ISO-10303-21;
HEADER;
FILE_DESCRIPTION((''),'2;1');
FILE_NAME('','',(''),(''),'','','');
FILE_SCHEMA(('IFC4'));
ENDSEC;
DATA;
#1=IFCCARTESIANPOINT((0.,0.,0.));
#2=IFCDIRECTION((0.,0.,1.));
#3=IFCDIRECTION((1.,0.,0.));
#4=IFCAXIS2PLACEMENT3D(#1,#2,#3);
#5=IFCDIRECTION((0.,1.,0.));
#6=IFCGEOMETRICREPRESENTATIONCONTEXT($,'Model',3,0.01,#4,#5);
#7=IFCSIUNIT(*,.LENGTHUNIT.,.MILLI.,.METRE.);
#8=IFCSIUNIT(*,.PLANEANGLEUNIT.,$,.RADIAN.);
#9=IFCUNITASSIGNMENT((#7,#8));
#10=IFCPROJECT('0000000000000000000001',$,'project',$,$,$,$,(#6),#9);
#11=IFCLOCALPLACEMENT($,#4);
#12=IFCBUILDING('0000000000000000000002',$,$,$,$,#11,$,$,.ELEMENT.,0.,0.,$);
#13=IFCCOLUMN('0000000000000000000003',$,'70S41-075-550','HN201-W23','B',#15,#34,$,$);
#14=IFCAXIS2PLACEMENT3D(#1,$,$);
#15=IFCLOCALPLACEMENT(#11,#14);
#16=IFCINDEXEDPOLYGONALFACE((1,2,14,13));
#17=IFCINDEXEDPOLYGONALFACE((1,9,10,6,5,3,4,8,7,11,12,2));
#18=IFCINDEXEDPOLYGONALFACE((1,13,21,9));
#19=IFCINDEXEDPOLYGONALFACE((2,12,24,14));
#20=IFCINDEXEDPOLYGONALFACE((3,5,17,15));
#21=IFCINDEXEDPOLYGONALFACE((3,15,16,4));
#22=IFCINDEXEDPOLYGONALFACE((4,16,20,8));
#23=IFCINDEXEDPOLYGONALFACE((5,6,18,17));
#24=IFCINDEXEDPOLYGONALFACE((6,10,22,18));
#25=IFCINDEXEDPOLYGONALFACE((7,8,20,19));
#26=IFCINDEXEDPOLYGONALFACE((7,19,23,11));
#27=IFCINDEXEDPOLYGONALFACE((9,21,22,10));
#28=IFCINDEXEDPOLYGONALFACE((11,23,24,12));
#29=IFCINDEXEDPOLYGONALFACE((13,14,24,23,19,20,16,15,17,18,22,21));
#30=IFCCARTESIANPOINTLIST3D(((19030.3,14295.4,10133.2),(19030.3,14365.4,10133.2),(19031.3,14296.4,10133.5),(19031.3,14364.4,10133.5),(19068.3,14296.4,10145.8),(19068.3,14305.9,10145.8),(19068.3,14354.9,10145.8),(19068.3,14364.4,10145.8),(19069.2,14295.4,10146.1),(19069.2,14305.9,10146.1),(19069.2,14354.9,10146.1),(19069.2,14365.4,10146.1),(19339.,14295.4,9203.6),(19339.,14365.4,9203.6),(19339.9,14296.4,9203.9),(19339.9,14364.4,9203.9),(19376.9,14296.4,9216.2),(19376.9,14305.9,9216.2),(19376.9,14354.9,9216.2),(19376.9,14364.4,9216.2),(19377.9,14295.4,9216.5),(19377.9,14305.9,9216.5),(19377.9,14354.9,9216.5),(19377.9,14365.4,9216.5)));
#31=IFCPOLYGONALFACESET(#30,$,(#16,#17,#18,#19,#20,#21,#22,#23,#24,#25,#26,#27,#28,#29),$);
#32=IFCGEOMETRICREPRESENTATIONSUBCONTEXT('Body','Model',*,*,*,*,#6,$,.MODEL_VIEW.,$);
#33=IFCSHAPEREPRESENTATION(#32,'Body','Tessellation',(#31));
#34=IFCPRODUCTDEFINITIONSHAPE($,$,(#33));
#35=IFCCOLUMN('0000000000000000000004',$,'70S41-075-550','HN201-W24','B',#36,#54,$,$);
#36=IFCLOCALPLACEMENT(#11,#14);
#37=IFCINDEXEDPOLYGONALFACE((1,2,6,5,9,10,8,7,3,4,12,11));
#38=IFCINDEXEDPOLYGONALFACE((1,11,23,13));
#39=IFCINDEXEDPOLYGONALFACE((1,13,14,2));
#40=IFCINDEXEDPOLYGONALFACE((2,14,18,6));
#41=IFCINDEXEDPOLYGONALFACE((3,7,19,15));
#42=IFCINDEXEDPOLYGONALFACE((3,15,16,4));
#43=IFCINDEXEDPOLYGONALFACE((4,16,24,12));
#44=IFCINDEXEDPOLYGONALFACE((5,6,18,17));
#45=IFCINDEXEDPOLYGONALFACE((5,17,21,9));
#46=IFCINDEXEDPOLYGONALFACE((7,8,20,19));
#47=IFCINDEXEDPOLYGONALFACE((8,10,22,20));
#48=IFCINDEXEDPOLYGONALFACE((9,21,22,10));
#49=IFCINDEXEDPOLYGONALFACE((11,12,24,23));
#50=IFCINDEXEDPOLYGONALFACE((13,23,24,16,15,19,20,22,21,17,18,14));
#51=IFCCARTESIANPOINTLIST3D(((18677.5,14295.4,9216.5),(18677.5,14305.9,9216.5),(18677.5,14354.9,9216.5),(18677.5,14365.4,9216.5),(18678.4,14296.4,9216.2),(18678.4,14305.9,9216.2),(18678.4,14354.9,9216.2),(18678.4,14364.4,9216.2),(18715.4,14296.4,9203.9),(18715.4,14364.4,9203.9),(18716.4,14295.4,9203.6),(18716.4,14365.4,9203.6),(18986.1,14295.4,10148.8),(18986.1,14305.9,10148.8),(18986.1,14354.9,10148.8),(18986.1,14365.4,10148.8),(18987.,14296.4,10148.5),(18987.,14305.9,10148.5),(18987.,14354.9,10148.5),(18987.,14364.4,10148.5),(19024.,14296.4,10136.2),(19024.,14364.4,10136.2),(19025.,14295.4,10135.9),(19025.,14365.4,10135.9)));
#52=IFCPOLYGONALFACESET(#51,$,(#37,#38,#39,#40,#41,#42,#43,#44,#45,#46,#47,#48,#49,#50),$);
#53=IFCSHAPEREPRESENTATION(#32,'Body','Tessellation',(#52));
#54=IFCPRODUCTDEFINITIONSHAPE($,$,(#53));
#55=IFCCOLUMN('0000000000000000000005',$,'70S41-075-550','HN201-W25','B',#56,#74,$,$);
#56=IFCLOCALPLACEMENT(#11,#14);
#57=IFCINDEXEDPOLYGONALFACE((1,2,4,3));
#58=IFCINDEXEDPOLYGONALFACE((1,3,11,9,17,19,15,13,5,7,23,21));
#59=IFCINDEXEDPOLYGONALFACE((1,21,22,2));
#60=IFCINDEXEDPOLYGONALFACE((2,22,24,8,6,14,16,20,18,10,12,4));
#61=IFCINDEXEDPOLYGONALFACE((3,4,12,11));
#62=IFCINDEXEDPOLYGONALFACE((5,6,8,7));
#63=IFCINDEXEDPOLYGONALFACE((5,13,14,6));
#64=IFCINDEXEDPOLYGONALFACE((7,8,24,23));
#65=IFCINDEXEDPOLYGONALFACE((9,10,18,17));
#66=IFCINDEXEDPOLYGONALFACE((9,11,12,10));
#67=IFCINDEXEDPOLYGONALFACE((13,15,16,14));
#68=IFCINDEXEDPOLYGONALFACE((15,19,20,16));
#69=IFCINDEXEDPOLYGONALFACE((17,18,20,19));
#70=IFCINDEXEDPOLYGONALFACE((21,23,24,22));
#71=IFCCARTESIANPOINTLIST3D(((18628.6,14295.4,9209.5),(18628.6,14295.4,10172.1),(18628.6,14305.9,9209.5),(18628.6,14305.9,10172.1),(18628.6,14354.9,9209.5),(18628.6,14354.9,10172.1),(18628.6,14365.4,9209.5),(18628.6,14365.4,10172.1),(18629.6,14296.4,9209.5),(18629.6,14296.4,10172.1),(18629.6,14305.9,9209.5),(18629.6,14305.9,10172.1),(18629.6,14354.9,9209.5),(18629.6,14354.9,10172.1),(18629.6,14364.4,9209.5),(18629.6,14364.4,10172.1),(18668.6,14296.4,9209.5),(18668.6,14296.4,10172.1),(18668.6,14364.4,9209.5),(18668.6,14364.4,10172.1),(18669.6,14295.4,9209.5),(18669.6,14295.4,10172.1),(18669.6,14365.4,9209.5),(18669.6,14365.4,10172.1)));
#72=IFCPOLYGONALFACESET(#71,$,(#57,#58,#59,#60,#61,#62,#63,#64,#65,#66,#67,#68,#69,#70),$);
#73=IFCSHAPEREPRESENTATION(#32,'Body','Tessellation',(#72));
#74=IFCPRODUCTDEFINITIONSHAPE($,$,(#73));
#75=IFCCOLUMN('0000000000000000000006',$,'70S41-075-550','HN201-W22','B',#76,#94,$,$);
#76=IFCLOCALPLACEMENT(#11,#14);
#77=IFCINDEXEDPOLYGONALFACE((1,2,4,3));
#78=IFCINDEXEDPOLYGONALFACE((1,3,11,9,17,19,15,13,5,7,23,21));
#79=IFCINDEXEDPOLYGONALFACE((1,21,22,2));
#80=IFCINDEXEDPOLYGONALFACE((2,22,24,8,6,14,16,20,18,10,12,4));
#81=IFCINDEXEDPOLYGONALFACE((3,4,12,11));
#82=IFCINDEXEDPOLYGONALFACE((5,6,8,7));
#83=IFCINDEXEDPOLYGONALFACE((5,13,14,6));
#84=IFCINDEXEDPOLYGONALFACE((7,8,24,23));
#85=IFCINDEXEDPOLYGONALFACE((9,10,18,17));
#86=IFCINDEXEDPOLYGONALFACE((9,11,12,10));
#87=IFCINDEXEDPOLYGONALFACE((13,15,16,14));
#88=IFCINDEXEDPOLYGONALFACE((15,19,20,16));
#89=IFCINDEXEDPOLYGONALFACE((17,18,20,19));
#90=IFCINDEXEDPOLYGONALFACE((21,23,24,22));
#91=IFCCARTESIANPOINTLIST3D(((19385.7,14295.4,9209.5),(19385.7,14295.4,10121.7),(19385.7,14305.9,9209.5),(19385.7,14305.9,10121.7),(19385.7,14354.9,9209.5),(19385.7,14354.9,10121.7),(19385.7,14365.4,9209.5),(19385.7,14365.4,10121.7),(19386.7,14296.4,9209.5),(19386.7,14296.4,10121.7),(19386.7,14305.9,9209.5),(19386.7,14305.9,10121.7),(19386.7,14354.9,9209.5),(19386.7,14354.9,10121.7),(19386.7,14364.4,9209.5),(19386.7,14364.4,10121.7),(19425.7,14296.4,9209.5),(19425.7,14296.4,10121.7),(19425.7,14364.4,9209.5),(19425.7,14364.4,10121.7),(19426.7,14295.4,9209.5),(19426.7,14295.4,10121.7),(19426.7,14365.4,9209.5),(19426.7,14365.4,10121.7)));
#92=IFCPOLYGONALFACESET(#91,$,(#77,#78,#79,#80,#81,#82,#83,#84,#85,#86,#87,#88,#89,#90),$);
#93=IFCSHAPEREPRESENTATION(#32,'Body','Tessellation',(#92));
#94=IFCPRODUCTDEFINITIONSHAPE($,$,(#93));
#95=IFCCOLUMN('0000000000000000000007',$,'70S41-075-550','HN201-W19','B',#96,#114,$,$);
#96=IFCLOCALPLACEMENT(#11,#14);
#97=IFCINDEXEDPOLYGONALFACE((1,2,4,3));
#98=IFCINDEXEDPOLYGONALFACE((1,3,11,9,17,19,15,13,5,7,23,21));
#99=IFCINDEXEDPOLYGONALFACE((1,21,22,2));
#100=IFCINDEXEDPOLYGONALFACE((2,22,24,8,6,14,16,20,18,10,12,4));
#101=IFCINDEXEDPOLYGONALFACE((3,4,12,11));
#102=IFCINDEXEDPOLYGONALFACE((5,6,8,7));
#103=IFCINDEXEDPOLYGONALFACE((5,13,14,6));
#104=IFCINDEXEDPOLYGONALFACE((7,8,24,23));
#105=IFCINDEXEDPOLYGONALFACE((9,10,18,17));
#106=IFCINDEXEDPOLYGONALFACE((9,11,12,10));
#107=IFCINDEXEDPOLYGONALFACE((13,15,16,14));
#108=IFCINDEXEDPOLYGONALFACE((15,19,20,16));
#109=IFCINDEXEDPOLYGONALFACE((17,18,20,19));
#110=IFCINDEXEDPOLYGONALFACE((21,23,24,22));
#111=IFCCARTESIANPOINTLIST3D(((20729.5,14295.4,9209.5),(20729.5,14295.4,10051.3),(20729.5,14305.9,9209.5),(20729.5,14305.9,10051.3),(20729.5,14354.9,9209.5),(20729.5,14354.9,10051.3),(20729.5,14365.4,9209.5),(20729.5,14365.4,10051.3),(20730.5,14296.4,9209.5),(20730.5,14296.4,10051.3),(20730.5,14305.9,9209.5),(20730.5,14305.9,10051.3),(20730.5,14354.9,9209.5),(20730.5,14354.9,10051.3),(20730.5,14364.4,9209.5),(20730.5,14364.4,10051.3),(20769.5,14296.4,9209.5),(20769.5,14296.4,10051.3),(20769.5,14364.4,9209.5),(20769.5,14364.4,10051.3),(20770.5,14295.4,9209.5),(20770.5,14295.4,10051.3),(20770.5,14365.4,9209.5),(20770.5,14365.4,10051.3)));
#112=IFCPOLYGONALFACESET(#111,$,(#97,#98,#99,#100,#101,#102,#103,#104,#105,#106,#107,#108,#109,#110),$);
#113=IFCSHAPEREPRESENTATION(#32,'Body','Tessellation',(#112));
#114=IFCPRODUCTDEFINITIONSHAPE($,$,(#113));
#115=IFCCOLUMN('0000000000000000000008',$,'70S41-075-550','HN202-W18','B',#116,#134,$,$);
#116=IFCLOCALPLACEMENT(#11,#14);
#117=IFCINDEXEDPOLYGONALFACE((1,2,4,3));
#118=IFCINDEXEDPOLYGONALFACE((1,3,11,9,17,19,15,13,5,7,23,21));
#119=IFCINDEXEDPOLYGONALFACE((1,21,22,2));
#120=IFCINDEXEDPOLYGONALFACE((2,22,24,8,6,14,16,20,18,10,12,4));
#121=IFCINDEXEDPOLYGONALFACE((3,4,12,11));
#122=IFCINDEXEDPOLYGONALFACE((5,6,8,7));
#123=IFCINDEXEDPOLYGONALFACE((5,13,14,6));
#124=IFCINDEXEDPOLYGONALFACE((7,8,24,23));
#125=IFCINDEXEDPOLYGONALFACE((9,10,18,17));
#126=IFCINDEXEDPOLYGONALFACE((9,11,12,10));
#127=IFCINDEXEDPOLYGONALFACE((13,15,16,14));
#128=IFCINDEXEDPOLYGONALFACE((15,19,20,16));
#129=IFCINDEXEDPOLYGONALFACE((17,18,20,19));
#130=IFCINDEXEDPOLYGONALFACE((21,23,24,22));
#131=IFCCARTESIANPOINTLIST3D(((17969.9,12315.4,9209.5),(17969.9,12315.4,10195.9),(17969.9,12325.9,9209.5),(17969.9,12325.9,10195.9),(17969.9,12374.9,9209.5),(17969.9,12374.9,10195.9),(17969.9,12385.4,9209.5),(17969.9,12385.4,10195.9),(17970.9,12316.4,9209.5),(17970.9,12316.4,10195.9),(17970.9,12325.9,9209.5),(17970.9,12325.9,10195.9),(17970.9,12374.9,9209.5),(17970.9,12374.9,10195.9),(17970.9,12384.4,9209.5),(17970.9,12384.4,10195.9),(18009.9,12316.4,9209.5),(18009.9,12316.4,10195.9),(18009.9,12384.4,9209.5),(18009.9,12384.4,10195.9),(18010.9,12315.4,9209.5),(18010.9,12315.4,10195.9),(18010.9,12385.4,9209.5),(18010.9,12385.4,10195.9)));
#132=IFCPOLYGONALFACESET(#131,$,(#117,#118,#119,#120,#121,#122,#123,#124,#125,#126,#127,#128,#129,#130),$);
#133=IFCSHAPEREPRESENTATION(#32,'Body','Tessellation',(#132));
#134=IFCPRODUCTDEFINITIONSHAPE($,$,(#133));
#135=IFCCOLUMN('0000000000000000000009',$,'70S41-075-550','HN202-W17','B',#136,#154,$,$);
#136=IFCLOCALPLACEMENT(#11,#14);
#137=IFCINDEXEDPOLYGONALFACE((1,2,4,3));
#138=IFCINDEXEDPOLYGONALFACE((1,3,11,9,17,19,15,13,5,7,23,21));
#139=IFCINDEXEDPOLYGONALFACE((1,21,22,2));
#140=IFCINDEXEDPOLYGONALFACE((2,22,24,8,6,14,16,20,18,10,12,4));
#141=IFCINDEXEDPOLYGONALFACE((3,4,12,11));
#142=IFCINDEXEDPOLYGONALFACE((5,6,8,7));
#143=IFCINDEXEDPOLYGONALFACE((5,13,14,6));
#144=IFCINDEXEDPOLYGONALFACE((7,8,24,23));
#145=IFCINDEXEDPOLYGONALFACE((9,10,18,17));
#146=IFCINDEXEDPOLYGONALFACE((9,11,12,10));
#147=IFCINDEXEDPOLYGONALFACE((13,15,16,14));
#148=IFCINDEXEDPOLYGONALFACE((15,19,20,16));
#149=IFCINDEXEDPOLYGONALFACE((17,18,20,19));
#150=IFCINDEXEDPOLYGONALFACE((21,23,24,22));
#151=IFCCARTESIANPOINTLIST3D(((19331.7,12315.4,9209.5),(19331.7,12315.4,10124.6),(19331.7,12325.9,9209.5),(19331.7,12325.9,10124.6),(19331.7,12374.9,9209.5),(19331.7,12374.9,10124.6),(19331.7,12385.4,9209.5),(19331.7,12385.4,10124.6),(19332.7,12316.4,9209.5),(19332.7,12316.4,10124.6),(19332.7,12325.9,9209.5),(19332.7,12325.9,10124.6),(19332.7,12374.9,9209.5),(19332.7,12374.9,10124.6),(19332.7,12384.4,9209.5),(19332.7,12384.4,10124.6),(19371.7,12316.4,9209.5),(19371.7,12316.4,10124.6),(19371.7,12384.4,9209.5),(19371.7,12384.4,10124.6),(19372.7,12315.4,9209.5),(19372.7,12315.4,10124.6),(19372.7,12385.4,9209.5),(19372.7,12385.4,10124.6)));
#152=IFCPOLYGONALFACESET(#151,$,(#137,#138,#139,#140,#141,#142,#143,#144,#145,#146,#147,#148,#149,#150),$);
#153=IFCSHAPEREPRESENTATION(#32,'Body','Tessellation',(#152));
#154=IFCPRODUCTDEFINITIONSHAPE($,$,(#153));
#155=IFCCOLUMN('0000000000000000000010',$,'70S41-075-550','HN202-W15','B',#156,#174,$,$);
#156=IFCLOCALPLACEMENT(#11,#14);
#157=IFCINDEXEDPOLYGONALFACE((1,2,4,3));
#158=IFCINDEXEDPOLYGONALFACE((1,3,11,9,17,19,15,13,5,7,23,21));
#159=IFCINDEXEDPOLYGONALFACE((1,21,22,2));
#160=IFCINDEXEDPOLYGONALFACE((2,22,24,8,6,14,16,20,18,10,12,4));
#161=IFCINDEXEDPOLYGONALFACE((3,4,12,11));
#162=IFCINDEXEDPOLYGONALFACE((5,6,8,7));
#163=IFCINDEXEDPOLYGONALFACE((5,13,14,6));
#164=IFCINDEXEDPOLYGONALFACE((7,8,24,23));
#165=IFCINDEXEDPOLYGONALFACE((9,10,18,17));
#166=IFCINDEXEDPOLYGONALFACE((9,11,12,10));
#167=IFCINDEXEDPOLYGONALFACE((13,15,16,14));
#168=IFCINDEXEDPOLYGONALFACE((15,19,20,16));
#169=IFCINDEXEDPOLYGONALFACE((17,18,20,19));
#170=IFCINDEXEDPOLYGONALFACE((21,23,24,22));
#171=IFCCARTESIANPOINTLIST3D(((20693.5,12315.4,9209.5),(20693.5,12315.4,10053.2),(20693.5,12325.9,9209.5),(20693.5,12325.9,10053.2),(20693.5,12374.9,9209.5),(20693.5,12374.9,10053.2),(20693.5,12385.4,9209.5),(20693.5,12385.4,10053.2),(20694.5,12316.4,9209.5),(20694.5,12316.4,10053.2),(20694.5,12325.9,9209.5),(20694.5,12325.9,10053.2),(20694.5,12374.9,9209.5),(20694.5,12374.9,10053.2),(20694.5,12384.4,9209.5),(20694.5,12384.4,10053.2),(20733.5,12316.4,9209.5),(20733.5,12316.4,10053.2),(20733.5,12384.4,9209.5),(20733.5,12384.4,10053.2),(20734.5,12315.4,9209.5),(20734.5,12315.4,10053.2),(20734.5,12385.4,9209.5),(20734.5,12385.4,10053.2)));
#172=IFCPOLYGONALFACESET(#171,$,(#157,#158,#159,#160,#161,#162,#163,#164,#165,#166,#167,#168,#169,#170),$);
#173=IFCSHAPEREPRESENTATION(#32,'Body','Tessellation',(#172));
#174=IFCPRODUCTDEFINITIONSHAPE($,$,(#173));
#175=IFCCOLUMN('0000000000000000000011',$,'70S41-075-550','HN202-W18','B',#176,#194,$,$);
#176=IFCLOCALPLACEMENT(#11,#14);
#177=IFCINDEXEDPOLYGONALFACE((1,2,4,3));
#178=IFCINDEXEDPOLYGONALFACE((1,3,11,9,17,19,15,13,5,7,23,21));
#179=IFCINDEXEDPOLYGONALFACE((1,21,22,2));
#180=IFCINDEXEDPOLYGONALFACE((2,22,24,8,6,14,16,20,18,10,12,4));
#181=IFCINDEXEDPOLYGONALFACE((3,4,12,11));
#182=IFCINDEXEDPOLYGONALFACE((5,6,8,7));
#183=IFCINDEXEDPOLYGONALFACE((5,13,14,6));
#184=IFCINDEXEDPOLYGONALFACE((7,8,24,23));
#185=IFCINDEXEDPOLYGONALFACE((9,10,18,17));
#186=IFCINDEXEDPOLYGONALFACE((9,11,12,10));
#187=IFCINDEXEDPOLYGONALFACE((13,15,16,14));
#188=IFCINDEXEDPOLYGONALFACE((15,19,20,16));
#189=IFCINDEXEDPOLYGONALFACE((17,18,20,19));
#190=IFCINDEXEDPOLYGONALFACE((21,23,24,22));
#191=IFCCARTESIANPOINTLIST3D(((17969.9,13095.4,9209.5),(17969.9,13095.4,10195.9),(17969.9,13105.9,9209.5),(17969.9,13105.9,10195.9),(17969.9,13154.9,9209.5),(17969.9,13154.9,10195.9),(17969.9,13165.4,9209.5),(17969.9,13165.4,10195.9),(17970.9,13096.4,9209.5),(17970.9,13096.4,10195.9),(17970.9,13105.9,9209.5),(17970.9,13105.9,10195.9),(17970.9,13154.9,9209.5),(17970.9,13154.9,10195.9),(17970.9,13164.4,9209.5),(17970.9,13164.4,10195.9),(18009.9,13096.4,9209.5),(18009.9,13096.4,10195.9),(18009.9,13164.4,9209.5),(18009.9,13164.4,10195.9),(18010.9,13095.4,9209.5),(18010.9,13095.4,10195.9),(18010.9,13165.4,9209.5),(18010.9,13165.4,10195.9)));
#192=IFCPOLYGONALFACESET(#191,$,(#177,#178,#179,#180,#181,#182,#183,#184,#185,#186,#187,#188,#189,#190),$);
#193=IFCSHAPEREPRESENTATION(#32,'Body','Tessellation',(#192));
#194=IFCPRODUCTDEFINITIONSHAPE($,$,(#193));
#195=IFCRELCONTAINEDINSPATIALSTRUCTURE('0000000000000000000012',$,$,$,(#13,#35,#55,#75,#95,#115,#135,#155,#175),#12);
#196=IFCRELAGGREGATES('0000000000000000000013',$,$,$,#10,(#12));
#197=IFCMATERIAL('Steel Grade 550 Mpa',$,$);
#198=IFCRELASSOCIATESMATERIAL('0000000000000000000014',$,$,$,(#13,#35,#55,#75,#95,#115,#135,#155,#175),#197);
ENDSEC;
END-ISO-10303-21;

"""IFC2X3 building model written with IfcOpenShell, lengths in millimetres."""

from ifc_helpers import new_model, si_unit, direction, frame, origin, origin_with_axes, origin_2d_with_axis, place, context, subcontext, project, spatial, c_section, extrude, source, transform, mapped, material, element, save


model = new_model("IFC2X3")

# Units and contexts
model_context = context("Model", 3, precision=0.01, world=origin_with_axes(), true_north=direction((0.0, 1.0, 0.0)))
body_context = subcontext(model_context, "Body", "Model", "MODEL_VIEW")
ifc_project = project(units=[si_unit("LENGTHUNIT", "METRE", prefix="MILLI"), si_unit("PLANEANGLEUNIT", "RADIAN")], contexts=[model_context])

# Building
building_placement = place(None, origin_with_axes())
building = spatial("IfcBuilding", under=ifc_project, at=building_placement, CompositionType="ELEMENT", ElevationOfRefHeight=0.0, ElevationOfTerrain=0.0)

# Columns
ifc_material = material(Name="Steel Grade 550 Mpa")
shared_shape_1 = source(origin(), body_context, "Body", "SweptSolid", [
    extrude(c_section(Depth=70.0, Width=41.0, WallThickness=1.0, Girth=10.5, at=origin_2d_with_axis()), origin_with_axes(), (0.0, 0.0, 1.0), 979.5),
])
column_1_placement = place(None, frame((19358.4, 14330.4, 9210.1), z_axis=(-0.315103, 0.0, 0.949058), x_axis=(0.949058, 0.0, 0.315103)))
element("IfcColumn", 1, at=column_1_placement, inside=building, material=ifc_material, Name="70S41-075-550", Description="HN201-W23", ObjectType="B", context=body_context, shape_type="MappedRepresentation", body=[
    mapped(shared_shape_1, transform((0.0, 0.0, 0.0), scale=1.0)),
])
shared_shape_2 = source(origin(), body_context, "Body", "SweptSolid", [
    extrude(c_section(Depth=70.0, Width=41.0, WallThickness=1.0, Girth=10.5, at=origin_2d_with_axis()), origin_with_axes(), (0.0, 0.0, 1.0), 982.0),
])
column_2_placement = place(None, frame((19005.5, 14330.4, 10142.3), z_axis=(-0.314267, 0.0, -0.949335), x_axis=(-0.949335, 0.0, 0.314267)))
element("IfcColumn", 2, at=column_2_placement, inside=building, material=ifc_material, Name="70S41-075-550", Description="HN201-W24", ObjectType="B", context=body_context, shape_type="MappedRepresentation", body=[
    mapped(shared_shape_2, transform((0.0, 0.0, 0.0), scale=1.0)),
])
shared_shape_3 = source(origin(), body_context, "Body", "SweptSolid", [
    extrude(c_section(Depth=70.0, Width=41.0, WallThickness=1.0, Girth=10.5, at=origin_2d_with_axis()), origin_with_axes(), (0.0, 0.0, 1.0), 962.6),
])
column_3_placement = place(None, frame((18649.1, 14330.4, 10172.1), z_axis=(0.0, 0.0, -1.0), x_axis=(-1.0, 0.0, 0.0)))
element("IfcColumn", 3, at=column_3_placement, inside=building, material=ifc_material, Name="70S41-075-550", Description="HN201-W25", ObjectType="B", context=body_context, shape_type="MappedRepresentation", body=[
    mapped(shared_shape_3, transform((0.0, 0.0, 0.0), scale=1.0)),
])
shared_shape_4 = source(origin(), body_context, "Body", "SweptSolid", [
    extrude(c_section(Depth=70.0, Width=41.0, WallThickness=1.0, Girth=10.5, at=origin_2d_with_axis()), origin_with_axes(), (0.0, 0.0, 1.0), 912.2),
])
column_4_placement = place(None, frame((19406.2, 14330.4, 10121.7), z_axis=(0.0, 0.0, -1.0), x_axis=(-1.0, 0.0, 0.0)))
element("IfcColumn", 4, at=column_4_placement, inside=building, material=ifc_material, Name="70S41-075-550", Description="HN201-W22", ObjectType="B", context=body_context, shape_type="MappedRepresentation", body=[
    mapped(shared_shape_4, transform((0.0, 0.0, 0.0), scale=1.0)),
])
shared_shape_5 = source(origin(), body_context, "Body", "SweptSolid", [
    extrude(c_section(Depth=70.0, Width=41.0, WallThickness=1.0, Girth=10.5, at=origin_2d_with_axis()), origin_with_axes(), (0.0, 0.0, 1.0), 841.8),
])
column_5_placement = place(None, frame((20750.0, 14330.4, 10051.3), z_axis=(0.0, 0.0, -1.0), x_axis=(-1.0, 0.0, 0.0)))
element("IfcColumn", 5, at=column_5_placement, inside=building, material=ifc_material, Name="70S41-075-550", Description="HN201-W19", ObjectType="B", context=body_context, shape_type="MappedRepresentation", body=[
    mapped(shared_shape_5, transform((0.0, 0.0, 0.0), scale=1.0)),
])
shared_shape_6 = source(origin(), body_context, "Body", "SweptSolid", [
    extrude(c_section(Depth=70.0, Width=41.0, WallThickness=1.0, Girth=10.5, at=origin_2d_with_axis()), origin_with_axes(), (0.0, 0.0, 1.0), 986.4),
])
column_6_placement = place(None, frame((17990.4, 12350.4, 10195.9), z_axis=(0.0, 0.0, -1.0), x_axis=(-1.0, 0.0, 0.0)))
element("IfcColumn", 6, at=column_6_placement, inside=building, material=ifc_material, Name="70S41-075-550", Description="HN202-W18", ObjectType="B", context=body_context, shape_type="MappedRepresentation", body=[
    mapped(shared_shape_6, transform((0.0, 0.0, 0.0), scale=1.0)),
])
shared_shape_7 = source(origin(), body_context, "Body", "SweptSolid", [
    extrude(c_section(Depth=70.0, Width=41.0, WallThickness=1.0, Girth=10.5, at=origin_2d_with_axis()), origin_with_axes(), (0.0, 0.0, 1.0), 915.1),
])
column_7_placement = place(None, frame((19352.2, 12350.4, 10124.6), z_axis=(0.0, 0.0, -1.0), x_axis=(-1.0, 0.0, 0.0)))
element("IfcColumn", 7, at=column_7_placement, inside=building, material=ifc_material, Name="70S41-075-550", Description="HN202-W17", ObjectType="B", context=body_context, shape_type="MappedRepresentation", body=[
    mapped(shared_shape_7, transform((0.0, 0.0, 0.0), scale=1.0)),
])
shared_shape_8 = source(origin(), body_context, "Body", "SweptSolid", [
    extrude(c_section(Depth=70.0, Width=41.0, WallThickness=1.0, Girth=10.5, at=origin_2d_with_axis()), origin_with_axes(), (0.0, 0.0, 1.0), 843.7),
])
column_8_placement = place(None, frame((20714.0, 12350.4, 10053.2), z_axis=(0.0, 0.0, -1.0), x_axis=(-1.0, 0.0, 0.0)))
element("IfcColumn", 8, at=column_8_placement, inside=building, material=ifc_material, Name="70S41-075-550", Description="HN202-W15", ObjectType="B", context=body_context, shape_type="MappedRepresentation", body=[
    mapped(shared_shape_8, transform((0.0, 0.0, 0.0), scale=1.0)),
])
shared_shape_9 = source(origin(), body_context, "Body", "SweptSolid", [
    extrude(c_section(Depth=70.0, Width=41.0, WallThickness=1.0, Girth=10.5, at=origin_2d_with_axis()), origin_with_axes(), (0.0, 0.0, 1.0), 986.4),
])
column_9_placement = place(None, frame((17990.4, 13130.4, 10195.9), z_axis=(0.0, 0.0, -1.0), x_axis=(-1.0, 0.0, 0.0)))
element("IfcColumn", 9, at=column_9_placement, inside=building, material=ifc_material, Name="70S41-075-550", Description="HN202-W18", ObjectType="B", context=body_context, shape_type="MappedRepresentation", body=[
    mapped(shared_shape_9, transform((0.0, 0.0, 0.0), scale=1.0)),
])

save(model, "model.ifc")
